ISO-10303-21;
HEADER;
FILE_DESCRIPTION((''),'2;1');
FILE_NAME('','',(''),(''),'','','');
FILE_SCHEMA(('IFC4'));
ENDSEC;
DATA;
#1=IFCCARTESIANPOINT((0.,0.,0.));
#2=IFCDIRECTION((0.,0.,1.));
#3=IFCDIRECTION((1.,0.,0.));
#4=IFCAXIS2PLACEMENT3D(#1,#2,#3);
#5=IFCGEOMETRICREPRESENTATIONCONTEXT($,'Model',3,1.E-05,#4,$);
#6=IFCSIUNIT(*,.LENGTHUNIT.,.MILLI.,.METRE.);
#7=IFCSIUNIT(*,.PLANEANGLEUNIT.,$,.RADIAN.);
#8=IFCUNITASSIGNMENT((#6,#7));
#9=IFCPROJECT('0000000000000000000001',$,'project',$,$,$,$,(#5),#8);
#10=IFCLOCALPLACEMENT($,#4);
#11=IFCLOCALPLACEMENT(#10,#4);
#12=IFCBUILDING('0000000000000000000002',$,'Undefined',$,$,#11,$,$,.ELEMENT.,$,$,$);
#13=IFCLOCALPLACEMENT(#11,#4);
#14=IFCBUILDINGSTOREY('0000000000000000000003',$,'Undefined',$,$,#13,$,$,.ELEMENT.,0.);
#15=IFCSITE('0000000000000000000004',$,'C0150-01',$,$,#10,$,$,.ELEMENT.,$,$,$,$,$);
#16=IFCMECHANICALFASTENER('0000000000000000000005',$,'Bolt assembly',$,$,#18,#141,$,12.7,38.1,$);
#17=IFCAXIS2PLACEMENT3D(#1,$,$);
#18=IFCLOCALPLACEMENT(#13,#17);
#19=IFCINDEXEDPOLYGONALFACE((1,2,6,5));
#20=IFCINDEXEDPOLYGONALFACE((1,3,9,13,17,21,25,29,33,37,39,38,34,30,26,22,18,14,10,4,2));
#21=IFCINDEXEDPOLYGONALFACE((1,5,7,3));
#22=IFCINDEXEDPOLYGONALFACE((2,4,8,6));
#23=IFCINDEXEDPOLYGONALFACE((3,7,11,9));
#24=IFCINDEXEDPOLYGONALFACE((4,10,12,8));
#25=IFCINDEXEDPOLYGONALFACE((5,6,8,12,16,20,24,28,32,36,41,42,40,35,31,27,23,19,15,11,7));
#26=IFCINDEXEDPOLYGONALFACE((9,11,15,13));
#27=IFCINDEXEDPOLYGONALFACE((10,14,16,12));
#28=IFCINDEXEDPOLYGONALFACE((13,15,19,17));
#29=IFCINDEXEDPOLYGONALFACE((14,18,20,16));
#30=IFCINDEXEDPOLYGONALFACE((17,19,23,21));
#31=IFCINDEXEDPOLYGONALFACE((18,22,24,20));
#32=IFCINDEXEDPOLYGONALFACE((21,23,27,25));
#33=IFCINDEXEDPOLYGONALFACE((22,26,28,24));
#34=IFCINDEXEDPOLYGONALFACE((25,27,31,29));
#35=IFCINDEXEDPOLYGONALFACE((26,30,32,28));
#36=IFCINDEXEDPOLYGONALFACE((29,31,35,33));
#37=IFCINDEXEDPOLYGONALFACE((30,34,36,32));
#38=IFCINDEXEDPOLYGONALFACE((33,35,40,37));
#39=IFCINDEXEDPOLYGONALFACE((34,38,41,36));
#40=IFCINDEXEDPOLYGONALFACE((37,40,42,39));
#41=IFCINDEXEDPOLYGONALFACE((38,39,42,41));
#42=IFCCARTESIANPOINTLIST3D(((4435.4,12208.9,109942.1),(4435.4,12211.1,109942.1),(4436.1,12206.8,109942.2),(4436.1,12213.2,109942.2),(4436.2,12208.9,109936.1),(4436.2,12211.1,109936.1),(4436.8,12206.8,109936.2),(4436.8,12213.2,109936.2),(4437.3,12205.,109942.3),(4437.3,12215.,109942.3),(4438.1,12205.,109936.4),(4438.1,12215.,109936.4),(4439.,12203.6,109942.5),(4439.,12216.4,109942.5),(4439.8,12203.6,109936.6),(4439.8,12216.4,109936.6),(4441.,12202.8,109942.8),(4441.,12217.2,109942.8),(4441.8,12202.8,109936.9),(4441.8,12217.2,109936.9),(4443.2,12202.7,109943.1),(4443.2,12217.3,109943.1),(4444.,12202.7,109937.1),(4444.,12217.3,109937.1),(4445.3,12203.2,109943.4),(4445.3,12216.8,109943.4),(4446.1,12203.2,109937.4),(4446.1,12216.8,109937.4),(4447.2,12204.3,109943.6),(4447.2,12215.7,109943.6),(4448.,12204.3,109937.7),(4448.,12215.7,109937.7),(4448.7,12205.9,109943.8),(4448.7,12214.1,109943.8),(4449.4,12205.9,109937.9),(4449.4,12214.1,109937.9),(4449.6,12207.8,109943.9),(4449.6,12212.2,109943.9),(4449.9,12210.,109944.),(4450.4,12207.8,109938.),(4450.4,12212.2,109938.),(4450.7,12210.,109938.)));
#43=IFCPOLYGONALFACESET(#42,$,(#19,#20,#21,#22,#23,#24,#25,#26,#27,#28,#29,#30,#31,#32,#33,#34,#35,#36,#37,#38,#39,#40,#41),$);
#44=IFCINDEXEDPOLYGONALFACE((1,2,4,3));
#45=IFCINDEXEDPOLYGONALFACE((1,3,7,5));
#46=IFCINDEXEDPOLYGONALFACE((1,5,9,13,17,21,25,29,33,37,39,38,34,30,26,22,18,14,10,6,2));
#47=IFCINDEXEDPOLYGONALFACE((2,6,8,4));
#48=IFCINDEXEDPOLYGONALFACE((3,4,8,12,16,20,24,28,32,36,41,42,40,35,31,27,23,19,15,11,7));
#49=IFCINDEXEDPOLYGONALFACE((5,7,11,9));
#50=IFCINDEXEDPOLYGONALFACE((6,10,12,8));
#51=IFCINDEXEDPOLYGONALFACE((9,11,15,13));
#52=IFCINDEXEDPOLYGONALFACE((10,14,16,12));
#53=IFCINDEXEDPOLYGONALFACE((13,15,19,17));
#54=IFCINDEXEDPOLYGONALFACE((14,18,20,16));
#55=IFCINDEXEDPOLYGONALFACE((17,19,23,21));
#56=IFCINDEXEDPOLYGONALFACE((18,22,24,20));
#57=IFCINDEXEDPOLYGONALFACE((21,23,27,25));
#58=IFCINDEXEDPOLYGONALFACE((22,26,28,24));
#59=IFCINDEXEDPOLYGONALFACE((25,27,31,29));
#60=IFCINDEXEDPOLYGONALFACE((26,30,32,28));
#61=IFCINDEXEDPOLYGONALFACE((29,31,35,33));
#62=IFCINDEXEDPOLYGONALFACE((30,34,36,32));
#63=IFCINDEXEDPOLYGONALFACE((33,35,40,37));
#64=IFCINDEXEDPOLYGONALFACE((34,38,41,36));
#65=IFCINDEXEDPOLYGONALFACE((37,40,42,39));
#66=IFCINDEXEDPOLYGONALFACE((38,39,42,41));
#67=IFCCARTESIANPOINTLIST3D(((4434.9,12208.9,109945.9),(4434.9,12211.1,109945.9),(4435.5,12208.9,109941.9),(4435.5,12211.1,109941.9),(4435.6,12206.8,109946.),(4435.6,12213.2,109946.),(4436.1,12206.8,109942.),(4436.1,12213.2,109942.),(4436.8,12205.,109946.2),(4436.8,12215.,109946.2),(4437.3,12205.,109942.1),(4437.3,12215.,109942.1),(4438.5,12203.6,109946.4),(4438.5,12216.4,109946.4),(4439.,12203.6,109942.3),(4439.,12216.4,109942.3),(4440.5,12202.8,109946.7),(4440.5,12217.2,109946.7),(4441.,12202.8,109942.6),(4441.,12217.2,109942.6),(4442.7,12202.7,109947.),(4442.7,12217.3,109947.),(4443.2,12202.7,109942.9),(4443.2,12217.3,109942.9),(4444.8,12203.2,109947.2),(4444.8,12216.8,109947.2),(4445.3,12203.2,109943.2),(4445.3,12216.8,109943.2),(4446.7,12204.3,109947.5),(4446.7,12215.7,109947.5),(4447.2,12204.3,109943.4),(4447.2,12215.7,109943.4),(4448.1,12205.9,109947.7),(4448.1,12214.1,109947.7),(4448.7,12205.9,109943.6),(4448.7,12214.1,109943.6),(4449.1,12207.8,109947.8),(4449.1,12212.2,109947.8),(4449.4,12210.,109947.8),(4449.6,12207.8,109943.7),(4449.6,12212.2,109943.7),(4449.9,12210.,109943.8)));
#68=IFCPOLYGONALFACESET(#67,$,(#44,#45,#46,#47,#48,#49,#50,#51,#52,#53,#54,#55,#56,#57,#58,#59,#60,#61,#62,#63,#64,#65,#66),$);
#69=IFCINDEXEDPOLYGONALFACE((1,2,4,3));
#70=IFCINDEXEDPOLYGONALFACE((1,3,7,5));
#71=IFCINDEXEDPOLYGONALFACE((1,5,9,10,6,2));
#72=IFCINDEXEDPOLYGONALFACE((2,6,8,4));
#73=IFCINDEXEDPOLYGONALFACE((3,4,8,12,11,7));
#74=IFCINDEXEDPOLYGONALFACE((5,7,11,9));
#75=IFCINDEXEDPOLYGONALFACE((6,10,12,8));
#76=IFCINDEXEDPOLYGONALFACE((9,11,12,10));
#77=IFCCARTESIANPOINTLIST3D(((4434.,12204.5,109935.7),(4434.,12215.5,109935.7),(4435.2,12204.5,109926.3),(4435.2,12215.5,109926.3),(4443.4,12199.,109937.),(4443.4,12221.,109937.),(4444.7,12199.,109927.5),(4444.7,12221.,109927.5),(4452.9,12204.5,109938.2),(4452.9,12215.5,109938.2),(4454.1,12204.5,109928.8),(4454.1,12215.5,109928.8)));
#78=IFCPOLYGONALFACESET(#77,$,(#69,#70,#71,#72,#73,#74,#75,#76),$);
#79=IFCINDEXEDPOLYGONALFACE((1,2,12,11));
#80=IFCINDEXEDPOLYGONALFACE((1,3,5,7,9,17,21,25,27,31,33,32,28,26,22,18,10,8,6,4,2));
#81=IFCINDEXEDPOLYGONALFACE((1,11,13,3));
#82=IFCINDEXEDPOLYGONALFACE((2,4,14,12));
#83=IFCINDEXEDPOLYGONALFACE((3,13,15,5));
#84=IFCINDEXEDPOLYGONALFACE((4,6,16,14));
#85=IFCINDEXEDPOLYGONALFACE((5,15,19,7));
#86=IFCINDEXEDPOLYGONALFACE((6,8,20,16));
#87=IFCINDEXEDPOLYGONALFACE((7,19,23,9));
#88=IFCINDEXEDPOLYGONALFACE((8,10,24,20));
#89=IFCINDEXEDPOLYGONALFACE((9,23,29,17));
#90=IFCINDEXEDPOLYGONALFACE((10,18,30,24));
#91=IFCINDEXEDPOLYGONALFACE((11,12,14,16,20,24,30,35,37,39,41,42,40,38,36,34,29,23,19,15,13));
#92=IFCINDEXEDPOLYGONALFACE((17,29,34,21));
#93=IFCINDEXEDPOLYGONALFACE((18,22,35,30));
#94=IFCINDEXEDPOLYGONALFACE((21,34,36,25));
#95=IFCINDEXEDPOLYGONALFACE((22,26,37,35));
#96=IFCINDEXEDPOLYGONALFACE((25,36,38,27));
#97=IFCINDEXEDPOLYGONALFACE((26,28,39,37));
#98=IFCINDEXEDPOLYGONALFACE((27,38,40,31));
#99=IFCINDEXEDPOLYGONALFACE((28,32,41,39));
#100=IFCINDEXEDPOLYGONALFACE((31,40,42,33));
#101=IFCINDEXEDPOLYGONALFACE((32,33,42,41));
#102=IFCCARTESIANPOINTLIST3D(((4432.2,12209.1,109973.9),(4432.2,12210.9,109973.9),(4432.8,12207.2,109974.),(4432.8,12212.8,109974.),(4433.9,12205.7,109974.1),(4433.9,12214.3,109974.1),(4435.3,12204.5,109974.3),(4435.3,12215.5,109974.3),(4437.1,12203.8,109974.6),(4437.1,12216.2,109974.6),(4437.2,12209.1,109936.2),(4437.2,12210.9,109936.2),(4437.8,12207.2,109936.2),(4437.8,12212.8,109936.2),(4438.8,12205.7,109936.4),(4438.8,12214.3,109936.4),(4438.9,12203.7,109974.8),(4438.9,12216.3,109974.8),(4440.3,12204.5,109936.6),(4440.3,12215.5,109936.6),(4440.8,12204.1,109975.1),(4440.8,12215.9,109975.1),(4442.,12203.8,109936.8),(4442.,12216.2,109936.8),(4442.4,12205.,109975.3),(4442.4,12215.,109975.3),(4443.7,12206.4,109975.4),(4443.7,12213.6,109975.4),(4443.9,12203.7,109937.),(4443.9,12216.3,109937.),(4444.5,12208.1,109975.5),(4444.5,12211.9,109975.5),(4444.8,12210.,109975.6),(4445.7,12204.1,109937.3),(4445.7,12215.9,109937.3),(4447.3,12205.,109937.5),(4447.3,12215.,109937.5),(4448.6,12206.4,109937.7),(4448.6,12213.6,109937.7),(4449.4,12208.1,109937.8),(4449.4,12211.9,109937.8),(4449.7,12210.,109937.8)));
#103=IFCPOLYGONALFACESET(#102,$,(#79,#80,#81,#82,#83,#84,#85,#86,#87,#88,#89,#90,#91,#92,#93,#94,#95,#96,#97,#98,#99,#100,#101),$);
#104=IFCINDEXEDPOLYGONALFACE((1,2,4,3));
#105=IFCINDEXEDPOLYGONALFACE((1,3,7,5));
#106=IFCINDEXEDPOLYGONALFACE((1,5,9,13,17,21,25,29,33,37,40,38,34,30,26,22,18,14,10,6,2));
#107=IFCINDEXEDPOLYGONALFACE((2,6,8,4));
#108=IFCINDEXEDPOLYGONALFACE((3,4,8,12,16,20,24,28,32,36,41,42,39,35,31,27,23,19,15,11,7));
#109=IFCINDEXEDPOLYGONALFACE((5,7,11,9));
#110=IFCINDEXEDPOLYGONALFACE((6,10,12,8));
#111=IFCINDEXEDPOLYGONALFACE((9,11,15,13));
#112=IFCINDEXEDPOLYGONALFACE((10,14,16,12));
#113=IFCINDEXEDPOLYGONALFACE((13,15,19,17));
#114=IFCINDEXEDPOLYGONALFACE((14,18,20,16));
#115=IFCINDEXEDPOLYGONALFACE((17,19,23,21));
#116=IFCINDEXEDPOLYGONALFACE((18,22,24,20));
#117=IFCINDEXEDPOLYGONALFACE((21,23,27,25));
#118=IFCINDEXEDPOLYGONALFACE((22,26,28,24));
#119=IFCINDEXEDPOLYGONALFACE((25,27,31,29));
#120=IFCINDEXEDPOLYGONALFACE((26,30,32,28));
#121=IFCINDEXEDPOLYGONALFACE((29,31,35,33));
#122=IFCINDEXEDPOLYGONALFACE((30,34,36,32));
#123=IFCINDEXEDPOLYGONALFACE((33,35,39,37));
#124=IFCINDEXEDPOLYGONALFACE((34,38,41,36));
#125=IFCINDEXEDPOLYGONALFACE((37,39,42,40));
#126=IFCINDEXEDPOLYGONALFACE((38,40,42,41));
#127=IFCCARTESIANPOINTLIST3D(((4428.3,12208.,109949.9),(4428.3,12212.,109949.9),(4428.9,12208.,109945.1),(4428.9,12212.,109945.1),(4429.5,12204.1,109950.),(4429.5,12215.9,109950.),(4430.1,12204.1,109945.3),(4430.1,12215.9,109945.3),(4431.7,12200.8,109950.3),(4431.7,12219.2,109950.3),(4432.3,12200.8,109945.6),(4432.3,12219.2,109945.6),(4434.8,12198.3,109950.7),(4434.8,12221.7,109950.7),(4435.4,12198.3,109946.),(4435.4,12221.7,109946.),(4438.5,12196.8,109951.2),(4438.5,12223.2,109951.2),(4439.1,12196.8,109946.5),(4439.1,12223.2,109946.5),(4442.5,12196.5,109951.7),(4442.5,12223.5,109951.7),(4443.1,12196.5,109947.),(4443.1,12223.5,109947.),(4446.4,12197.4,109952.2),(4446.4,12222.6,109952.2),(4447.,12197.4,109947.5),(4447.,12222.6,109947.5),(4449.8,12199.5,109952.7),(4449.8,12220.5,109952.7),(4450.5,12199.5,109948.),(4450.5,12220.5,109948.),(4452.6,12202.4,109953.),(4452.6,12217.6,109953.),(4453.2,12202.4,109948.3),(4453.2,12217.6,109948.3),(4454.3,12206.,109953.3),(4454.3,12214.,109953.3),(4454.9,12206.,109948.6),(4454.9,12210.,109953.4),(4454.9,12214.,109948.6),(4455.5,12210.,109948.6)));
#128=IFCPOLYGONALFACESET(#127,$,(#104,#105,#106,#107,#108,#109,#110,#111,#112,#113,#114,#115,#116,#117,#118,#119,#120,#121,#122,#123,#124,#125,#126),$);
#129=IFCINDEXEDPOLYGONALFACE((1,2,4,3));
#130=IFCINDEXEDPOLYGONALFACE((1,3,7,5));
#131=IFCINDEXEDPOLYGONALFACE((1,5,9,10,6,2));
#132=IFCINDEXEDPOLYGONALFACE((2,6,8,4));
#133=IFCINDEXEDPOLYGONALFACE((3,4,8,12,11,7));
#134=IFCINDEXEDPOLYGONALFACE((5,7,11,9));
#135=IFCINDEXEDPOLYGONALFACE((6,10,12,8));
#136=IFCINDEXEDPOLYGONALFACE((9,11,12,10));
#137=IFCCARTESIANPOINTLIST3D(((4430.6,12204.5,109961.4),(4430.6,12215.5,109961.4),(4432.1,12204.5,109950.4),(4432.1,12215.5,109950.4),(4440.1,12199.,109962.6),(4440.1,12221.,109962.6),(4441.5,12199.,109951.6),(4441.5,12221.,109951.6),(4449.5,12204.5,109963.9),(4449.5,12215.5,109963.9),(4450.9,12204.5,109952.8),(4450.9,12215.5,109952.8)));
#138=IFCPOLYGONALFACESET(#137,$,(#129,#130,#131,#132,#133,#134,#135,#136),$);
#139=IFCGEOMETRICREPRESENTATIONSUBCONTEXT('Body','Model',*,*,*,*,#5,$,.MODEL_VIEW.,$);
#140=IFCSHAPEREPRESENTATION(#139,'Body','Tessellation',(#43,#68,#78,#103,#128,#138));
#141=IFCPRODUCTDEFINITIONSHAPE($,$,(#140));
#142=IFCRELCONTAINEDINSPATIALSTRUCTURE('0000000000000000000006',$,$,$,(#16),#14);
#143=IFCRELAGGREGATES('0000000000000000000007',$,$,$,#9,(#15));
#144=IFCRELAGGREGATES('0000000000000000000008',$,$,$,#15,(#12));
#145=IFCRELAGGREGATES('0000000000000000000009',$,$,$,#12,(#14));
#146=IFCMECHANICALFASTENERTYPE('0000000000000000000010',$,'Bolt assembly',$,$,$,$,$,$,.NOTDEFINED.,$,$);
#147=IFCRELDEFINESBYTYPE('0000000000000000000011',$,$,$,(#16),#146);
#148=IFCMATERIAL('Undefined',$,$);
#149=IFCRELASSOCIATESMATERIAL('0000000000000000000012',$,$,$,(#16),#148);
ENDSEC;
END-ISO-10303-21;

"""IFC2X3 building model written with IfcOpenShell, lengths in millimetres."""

from ifc_helpers import new_model, si_unit, frame, origin_with_axes, origin_2d_with_axis, place, context, subcontext, project, spatial, polyline, circle, outline, extrude, source, transform, mapped, material, type_object, element, save


model = new_model("IFC2X3")

# Units and contexts
model_context = context("Model", 3, precision=1e-05, world=origin_with_axes())
body_context = subcontext(model_context, "Body", "Model", "MODEL_VIEW")
ifc_project = project(units=[si_unit("LENGTHUNIT", "METRE", prefix="MILLI"), si_unit("PLANEANGLEUNIT", "RADIAN")], contexts=[model_context])

# Site, building, storey
site_placement = place(None, origin_with_axes())
site = spatial("IfcSite", under=ifc_project, at=site_placement, Name="C0150-01", CompositionType="ELEMENT")
building_placement = place(site_placement, origin_with_axes())
building = spatial("IfcBuilding", under=site, at=building_placement, Name="Undefined", CompositionType="ELEMENT")
storey_placement = place(building_placement, origin_with_axes())
storey = spatial("IfcBuildingStorey", under=building, at=storey_placement, Name="Undefined", CompositionType="ELEMENT", Elevation=0.0)

# Mechanical fastener
ifc_material_1 = material(Name="Undefined")
mechanical_fastener_type = type_object("IfcMechanicalFastenerType", Name="Bolt assembly")
shared_shape_1 = source(origin_with_axes(), body_context, "Body", "SweptSolid", [
    extrude(circle(Radius=7.3, at=origin_2d_with_axis()), frame((0.0, -9.9, 0.0), z_axis=(0.0, 1.0, 0.0), x_axis=(1.0, 0.0, 0.0)), (0.0, 0.0, 1.0), 6.0),
    extrude(circle(Radius=7.3, at=origin_2d_with_axis()), frame((0.0, -4.1, 0.0), z_axis=(0.0, 1.0, 0.0), x_axis=(1.0, 0.0, 0.0)), (0.0, 0.0, 1.0), 4.1),
    extrude(outline(polyline([(9.5, -5.5), (9.5, 5.5), (0.0, 11.0), (-9.5, 5.5), (-9.5, -5.5), (0.0, -11.0), (9.5, -5.5)])), frame((0.0, -19.5, 0.0), z_axis=(0.0, 1.0, 0.0), x_axis=(1.0, 0.0, 0.0)), (0.0, 0.0, 1.0), 9.5),
    extrude(circle(Radius=6.3, at=origin_2d_with_axis()), frame((0.0, -10.0, 0.0), z_axis=(0.0, 1.0, 0.0), x_axis=(1.0, 0.0, 0.0)), (0.0, 0.0, 1.0), 38.1),
    extrude(circle(Radius=13.5, at=origin_2d_with_axis()), frame((0.0, 0.0, 0.0), z_axis=(0.0, 1.0, 0.0), x_axis=(1.0, 0.0, 0.0)), (0.0, 0.0, 1.0), 4.8),
    extrude(outline(polyline([(9.5, -5.5), (9.5, 5.5), (0.0, 11.0), (-9.5, 5.5), (-9.5, -5.5), (0.0, -11.0), (9.5, -5.5)])), frame((0.0, 4.8, 0.0), z_axis=(0.0, 1.0, 0.0), x_axis=(1.0, 0.0, 0.0)), (0.0, 0.0, 1.0), 11.1),
])
for number, where, z_axis, x_axis, name in (
    (1, (4442.1, 12210.0, 109946.9), (0.0, -1.0, 0.0), (0.991507, 0.0, 0.130054), "Bolt assembly"),
):
    element("IfcMechanicalFastener", number, at=place(storey_placement, frame(where, z_axis=z_axis, x_axis=x_axis)), inside=storey, type_object=mechanical_fastener_type, material=ifc_material_1, Name=name, NominalDiameter=12.7, NominalLength=38.1, context=body_context, shape_type="MappedRepresentation", body=[
        mapped(shared_shape_1, transform((0.0, 0.0, 0.0))),
    ])

save(model, "model.ifc")
